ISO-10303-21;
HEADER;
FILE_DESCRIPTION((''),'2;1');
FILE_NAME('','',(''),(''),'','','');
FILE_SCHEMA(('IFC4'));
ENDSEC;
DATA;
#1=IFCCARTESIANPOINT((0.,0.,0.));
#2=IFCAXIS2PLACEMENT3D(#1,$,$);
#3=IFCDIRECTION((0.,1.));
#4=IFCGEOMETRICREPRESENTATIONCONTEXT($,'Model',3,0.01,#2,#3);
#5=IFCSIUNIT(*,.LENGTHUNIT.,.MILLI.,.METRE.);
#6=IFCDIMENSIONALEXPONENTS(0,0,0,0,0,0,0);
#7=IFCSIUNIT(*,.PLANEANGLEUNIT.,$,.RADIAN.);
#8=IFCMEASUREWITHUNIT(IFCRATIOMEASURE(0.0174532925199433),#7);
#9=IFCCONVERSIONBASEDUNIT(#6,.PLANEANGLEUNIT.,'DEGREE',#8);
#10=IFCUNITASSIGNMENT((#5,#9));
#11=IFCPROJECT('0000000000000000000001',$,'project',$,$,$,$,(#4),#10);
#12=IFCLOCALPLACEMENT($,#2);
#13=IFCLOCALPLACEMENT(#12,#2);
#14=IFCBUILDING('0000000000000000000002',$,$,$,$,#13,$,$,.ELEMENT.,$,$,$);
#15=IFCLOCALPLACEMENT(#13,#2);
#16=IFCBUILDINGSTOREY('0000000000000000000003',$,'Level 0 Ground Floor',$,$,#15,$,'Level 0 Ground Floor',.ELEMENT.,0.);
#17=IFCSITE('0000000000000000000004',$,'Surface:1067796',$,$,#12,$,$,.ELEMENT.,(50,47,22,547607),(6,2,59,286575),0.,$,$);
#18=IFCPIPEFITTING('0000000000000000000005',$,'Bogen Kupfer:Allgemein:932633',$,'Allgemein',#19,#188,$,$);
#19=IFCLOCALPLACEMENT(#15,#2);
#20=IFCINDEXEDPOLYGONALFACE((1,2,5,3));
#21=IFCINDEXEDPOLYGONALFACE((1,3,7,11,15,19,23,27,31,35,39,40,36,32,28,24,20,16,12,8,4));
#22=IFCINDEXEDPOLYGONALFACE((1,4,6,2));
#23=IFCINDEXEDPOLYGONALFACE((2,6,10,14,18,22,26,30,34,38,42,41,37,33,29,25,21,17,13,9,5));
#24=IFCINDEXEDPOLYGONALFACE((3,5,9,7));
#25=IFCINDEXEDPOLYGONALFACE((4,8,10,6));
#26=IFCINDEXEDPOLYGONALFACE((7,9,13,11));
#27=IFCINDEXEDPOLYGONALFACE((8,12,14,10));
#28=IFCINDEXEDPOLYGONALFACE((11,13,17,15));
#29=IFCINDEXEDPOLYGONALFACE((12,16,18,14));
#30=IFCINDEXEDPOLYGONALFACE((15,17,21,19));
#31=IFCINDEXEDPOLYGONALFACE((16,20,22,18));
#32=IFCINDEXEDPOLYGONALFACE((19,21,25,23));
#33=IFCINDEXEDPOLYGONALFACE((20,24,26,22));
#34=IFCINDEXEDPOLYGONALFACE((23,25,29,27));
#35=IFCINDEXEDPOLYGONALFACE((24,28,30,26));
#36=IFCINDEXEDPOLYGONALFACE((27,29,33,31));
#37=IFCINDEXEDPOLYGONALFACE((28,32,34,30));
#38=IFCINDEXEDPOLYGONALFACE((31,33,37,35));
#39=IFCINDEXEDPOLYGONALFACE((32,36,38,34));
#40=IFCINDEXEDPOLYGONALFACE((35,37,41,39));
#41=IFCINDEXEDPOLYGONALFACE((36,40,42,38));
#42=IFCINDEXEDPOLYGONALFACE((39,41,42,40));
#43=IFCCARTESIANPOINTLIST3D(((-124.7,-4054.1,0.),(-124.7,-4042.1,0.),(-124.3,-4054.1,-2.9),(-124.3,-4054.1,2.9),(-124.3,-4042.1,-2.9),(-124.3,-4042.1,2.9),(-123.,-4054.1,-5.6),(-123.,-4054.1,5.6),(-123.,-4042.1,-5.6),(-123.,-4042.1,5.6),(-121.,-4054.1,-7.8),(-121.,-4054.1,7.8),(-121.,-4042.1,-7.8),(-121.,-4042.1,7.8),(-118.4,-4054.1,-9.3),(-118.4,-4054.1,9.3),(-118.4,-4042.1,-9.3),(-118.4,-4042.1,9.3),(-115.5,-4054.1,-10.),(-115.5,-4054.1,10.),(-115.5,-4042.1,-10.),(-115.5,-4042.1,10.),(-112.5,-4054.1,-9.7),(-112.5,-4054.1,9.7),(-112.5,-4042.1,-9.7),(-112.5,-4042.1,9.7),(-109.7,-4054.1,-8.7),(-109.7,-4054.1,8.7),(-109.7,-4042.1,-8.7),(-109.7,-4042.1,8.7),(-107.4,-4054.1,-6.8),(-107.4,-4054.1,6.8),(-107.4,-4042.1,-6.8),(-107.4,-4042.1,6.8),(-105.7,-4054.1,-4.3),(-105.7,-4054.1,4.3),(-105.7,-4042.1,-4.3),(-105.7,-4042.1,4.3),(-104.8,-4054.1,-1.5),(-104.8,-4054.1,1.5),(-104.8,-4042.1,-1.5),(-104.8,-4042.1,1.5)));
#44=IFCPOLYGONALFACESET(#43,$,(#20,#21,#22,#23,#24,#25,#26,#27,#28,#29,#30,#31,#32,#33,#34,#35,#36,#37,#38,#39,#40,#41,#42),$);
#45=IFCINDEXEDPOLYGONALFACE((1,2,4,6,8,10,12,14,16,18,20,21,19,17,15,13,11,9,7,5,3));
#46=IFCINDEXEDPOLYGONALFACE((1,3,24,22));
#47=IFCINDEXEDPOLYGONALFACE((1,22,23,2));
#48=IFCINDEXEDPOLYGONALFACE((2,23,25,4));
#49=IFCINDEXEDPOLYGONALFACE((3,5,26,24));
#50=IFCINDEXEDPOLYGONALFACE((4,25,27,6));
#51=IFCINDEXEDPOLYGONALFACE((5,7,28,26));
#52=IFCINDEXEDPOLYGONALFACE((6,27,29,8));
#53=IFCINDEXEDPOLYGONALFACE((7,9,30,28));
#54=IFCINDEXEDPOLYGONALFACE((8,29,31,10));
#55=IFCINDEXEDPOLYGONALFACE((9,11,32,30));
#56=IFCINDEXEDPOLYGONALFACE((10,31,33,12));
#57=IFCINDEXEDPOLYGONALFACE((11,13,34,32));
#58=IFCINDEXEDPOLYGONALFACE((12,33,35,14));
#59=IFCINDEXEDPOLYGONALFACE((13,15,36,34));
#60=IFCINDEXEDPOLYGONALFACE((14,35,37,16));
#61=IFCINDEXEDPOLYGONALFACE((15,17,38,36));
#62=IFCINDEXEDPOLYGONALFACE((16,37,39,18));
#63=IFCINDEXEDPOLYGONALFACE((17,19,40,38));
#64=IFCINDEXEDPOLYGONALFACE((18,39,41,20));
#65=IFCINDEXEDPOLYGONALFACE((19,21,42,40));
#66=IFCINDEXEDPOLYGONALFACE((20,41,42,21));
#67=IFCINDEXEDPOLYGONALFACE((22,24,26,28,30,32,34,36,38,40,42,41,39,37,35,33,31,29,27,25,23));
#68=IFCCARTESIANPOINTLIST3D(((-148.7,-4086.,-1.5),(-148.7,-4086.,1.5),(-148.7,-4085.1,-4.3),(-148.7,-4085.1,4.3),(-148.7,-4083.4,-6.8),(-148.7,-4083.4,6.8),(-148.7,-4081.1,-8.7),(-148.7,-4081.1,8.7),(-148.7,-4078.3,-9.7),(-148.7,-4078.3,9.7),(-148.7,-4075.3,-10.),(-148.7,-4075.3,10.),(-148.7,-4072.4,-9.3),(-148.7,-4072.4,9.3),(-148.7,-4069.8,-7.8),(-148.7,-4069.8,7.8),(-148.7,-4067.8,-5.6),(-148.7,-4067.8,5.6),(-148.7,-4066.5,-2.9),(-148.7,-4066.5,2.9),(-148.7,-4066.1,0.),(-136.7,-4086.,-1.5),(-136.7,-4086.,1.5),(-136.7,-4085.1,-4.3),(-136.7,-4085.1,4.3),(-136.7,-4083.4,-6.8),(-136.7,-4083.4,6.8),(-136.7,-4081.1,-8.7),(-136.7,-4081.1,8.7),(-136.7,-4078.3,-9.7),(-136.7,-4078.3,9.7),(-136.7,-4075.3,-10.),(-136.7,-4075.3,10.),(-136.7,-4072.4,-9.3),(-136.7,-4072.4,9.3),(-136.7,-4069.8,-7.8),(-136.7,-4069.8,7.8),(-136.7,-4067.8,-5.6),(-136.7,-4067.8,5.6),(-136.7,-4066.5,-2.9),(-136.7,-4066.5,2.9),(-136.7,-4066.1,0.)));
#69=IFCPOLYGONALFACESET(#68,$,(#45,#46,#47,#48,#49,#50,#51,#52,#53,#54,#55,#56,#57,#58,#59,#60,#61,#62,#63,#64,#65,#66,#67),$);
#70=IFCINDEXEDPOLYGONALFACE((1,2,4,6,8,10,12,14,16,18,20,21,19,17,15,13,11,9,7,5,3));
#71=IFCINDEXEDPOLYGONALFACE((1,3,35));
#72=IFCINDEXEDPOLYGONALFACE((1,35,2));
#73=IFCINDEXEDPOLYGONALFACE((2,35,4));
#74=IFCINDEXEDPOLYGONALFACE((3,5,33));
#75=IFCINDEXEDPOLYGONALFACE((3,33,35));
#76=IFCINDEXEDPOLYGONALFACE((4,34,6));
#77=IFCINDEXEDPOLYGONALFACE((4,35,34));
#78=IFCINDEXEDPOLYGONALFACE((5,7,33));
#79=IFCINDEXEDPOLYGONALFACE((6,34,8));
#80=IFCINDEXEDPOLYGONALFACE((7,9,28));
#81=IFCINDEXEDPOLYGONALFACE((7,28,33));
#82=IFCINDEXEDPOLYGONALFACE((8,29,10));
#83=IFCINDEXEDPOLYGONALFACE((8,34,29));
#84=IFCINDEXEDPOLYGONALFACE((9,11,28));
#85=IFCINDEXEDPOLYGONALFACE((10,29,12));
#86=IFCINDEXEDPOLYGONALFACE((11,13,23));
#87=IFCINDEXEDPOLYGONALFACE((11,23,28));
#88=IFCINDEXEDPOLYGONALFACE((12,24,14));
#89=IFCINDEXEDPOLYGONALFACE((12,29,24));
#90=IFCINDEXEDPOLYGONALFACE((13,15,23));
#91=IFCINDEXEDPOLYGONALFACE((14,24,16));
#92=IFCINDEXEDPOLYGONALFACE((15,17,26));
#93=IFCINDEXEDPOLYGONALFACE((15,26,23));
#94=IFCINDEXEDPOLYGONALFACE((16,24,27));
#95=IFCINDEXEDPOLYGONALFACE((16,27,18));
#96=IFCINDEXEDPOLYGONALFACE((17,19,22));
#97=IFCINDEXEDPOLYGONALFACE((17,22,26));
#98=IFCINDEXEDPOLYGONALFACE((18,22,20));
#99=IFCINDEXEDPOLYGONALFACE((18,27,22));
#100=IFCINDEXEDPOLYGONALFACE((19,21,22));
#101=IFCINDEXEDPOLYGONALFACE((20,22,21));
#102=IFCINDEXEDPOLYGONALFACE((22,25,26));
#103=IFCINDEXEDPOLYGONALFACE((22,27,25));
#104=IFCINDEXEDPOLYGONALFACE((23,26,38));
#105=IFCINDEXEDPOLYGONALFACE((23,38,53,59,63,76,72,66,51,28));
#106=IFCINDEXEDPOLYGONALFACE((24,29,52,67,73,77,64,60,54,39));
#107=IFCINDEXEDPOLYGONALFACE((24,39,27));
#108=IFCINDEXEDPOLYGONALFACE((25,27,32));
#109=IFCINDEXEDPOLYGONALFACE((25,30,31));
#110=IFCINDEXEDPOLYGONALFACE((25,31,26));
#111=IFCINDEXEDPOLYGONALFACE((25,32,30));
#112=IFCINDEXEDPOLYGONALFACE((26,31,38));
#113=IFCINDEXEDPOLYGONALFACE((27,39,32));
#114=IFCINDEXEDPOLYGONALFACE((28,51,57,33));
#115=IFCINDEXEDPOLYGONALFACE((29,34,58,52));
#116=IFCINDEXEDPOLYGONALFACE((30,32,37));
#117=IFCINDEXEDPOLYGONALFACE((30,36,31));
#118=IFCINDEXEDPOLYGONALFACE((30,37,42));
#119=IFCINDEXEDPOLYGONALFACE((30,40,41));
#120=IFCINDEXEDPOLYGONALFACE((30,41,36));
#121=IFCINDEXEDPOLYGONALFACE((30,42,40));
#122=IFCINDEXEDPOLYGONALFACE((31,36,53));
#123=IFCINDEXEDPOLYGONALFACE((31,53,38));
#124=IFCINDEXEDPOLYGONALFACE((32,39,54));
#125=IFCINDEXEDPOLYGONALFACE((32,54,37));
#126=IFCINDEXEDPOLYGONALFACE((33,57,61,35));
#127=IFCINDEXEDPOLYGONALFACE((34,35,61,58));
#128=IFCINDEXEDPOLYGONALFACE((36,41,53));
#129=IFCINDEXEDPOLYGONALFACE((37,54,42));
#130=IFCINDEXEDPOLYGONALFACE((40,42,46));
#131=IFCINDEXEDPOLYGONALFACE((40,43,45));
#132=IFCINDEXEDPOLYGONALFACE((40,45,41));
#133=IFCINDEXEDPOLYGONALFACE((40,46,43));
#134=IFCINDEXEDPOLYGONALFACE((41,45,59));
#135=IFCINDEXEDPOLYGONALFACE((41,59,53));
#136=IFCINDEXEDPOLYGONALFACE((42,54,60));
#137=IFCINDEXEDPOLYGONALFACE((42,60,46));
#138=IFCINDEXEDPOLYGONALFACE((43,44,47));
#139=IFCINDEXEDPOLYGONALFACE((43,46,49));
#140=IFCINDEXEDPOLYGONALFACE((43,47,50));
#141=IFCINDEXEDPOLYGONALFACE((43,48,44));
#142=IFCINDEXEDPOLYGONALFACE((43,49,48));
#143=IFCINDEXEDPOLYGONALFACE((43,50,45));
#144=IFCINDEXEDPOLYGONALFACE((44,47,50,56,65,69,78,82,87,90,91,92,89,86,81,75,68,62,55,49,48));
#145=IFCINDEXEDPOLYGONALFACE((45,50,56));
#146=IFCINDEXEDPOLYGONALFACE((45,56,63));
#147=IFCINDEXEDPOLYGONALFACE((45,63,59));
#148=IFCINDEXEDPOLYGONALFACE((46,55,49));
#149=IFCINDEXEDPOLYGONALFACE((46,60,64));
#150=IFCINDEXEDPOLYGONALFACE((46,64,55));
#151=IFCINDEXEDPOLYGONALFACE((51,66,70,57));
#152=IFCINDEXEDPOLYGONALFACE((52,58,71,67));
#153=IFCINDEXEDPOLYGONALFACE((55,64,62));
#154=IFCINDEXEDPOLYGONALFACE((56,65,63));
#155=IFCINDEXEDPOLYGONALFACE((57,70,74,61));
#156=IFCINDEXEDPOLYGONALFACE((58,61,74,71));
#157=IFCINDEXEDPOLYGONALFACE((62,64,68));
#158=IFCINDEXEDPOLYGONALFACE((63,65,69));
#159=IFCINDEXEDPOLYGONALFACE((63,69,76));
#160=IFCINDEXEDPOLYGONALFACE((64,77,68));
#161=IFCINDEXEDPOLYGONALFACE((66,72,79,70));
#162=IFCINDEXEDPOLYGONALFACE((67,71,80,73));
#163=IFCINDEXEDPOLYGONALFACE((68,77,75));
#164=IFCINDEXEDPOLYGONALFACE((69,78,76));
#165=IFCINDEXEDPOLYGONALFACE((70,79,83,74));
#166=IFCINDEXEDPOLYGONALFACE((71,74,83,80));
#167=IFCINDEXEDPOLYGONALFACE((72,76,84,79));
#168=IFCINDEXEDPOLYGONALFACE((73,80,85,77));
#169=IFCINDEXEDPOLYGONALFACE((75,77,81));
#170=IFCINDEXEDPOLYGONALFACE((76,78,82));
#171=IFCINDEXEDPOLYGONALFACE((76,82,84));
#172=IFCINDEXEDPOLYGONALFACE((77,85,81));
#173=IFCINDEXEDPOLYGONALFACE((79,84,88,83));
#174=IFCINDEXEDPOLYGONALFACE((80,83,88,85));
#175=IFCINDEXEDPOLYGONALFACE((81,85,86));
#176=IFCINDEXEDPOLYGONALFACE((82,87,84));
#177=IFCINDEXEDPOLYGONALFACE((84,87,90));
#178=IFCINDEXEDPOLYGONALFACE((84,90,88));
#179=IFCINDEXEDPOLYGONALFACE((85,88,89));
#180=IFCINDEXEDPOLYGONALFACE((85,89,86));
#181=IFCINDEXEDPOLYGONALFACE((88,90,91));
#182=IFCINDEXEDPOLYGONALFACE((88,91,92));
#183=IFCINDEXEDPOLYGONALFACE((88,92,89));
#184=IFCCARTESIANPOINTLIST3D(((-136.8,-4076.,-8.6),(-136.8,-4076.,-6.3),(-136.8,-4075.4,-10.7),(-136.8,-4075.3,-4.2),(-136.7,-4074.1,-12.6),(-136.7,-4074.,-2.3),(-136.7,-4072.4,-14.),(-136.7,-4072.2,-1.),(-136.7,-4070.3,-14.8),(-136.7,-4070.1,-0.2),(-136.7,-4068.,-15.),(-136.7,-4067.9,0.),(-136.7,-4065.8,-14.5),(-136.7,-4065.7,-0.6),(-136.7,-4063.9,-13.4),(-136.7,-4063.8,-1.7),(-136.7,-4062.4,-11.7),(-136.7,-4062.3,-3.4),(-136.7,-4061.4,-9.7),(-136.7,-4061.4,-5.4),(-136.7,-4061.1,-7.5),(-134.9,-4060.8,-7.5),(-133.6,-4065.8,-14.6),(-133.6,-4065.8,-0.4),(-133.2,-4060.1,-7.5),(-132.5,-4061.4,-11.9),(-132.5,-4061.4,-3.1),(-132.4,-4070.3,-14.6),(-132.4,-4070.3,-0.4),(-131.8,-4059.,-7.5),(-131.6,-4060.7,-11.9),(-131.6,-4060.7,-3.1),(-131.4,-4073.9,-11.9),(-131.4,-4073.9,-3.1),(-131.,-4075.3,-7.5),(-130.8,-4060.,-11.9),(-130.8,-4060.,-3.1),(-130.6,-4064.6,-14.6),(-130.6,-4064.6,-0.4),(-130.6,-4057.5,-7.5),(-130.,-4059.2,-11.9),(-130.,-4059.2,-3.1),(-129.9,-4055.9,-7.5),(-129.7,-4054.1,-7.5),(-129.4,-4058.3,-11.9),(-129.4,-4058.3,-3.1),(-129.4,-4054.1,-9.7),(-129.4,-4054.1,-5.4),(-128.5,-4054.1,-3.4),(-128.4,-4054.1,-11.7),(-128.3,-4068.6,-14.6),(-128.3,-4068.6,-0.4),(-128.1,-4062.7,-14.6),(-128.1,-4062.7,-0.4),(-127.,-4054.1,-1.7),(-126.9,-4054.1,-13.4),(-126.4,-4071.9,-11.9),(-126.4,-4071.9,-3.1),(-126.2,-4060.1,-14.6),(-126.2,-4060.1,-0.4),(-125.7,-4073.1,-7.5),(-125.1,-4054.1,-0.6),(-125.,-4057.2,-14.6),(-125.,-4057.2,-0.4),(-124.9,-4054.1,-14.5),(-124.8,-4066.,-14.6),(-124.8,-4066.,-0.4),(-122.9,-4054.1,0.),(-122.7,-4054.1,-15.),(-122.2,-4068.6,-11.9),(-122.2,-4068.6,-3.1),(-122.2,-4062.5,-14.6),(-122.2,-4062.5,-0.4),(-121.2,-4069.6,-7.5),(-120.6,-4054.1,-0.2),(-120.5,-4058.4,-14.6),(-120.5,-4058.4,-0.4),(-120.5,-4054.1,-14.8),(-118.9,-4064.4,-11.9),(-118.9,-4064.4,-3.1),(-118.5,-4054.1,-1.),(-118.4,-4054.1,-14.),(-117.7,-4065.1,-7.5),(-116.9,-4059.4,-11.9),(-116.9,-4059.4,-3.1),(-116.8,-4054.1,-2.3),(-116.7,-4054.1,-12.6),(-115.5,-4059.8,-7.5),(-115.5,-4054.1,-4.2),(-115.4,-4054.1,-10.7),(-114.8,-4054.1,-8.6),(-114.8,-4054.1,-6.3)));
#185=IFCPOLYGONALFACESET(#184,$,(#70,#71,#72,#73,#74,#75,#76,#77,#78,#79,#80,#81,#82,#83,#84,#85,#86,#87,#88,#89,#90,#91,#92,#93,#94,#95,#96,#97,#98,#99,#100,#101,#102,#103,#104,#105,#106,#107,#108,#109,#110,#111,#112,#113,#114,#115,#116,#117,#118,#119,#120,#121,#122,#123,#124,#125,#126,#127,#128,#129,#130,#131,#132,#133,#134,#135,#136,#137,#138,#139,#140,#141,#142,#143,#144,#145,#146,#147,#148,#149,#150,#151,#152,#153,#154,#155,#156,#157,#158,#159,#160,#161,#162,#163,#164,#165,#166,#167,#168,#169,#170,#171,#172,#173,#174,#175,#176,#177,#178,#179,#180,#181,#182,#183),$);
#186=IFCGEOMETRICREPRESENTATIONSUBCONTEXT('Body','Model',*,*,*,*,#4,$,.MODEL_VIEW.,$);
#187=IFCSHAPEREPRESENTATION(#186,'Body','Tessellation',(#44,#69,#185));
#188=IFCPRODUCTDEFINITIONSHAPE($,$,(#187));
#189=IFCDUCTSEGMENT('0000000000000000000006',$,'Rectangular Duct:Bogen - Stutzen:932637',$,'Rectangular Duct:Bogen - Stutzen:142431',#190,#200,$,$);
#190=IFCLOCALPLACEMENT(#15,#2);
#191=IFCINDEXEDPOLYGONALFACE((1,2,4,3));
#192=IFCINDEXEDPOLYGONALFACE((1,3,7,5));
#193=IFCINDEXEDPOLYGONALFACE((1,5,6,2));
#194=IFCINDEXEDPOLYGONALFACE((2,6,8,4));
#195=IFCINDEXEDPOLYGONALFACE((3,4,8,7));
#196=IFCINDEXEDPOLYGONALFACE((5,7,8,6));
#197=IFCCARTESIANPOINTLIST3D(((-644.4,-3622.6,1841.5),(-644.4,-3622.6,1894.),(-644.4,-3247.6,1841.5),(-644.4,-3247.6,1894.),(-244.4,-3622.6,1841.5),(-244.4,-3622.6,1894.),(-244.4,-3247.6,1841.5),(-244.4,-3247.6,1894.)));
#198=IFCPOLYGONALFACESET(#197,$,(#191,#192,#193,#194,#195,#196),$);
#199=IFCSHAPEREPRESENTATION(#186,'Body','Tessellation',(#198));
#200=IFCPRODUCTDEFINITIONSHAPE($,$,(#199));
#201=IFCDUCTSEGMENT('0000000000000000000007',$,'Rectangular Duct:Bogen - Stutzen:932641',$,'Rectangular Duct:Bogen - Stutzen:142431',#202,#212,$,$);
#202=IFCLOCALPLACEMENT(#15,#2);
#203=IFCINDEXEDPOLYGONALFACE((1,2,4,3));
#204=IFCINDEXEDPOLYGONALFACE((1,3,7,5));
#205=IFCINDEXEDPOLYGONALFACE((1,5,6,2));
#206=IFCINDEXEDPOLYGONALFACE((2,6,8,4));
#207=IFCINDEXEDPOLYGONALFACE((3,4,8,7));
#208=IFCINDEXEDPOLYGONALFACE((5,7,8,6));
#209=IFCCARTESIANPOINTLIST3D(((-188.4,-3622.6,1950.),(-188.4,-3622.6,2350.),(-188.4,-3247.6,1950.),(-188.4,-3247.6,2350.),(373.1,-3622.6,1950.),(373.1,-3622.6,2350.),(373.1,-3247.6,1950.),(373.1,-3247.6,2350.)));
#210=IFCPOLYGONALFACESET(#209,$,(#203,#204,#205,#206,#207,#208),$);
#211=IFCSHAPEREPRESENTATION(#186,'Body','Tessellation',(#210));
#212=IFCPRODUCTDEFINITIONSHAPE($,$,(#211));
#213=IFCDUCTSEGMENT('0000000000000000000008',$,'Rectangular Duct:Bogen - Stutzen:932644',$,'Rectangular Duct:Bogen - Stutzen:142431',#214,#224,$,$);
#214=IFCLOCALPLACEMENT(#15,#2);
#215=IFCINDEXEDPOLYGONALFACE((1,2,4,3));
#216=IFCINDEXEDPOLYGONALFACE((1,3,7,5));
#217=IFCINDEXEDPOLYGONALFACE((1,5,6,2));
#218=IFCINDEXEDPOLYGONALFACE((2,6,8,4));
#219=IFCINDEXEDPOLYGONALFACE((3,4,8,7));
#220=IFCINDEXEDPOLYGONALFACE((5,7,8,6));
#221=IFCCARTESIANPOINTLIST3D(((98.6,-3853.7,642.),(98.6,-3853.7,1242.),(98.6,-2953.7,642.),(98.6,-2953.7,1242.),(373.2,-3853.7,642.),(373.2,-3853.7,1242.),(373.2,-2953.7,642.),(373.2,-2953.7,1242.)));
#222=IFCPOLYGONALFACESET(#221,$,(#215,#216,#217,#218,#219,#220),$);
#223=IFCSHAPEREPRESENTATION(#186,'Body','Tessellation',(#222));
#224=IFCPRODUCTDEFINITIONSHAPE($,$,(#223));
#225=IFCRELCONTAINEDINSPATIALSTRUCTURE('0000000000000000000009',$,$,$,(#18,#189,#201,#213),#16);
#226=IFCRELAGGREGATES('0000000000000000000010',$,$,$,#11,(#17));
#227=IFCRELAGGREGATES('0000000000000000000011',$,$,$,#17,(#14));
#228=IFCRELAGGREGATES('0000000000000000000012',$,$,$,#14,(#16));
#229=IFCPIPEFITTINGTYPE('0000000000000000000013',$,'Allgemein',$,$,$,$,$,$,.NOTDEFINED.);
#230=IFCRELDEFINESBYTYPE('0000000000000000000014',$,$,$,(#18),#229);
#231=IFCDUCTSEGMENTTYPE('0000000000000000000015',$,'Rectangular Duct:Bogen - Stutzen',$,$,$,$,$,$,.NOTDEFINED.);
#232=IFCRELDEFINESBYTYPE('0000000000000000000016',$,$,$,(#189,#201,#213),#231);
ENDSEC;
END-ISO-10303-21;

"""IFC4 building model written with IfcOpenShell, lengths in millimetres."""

from ifc_helpers import new_model, entity, si_unit, converted_unit, direction, frame, frame_2d, origin, origin_2d_with_axis, place, context, subcontext, project, spatial, rectangle, circle, extrude, source, transform, mapped, type_object, type_shapes, element, save


model = new_model("IFC4")

# Units and contexts
model_context = context("Model", 3, precision=0.01, world=origin(), true_north=direction((0.0, 1.0)))
body_context = subcontext(model_context, "Body", "Model", "MODEL_VIEW")
ifc_project = project(units=[si_unit("LENGTHUNIT", "METRE", prefix="MILLI"), converted_unit("PLANEANGLEUNIT", "DEGREE", entity("IfcRatioMeasure", 0.0174532925199433), si_unit("PLANEANGLEUNIT", "RADIAN"), dimensions=[0, 0, 0, 0, 0, 0, 0])], contexts=[model_context])

# Site, building, storey
site_placement = place(None, origin())
site = spatial("IfcSite", under=ifc_project, at=site_placement, Name="Surface:1067796", CompositionType="ELEMENT", RefLatitude=(50, 47, 22, 547607), RefLongitude=(6, 2, 59, 286575), RefElevation=0.0)
building_placement = place(site_placement, origin())
building = spatial("IfcBuilding", under=site, at=building_placement, CompositionType="ELEMENT")
storey_placement = place(building_placement, origin())
storey = spatial("IfcBuildingStorey", under=building, at=storey_placement, Name="Level 0 Ground Floor", LongName="Level 0 Ground Floor", CompositionType="ELEMENT", Elevation=0.0)

# Pipe fitting
pipe_fitting_type_1 = type_object("IfcPipeFittingType", Name="Allgemein", PredefinedType="NOTDEFINED")
ifc_direction = entity("IfcDirection", [0.0, 0.0, -1.0])
trimmed_curve = entity("IfcTrimmedCurve", entity("IfcCircle", entity("IfcAxis2Placement2D", entity("IfcCartesianPoint", [-14.5, 0.0]), entity("IfcDirection", [0.0, 1.0])), 14.5), [entity("IfcParameterValue", 270.0)], [entity("IfcParameterValue", 0.0)], True, "PARAMETER")
shared_shape_1 = source(origin(), body_context, "Body", "SolidModel", [
    extrude(circle(Radius=10.0, at=frame_2d((0.0, 0.0), x_axis=(1.0, 0.0))), frame((0.0, 22.0, 0.0), z_axis=(0.0, 1.0, 0.0), x_axis=(-1.0, 0.0, 0.0)), (0.0, 0.0, 1.0), 12.0),
    extrude(circle(Radius=10.0, at=frame_2d((0.0, 0.0), x_axis=(1.0, 0.0))), frame((-34.0, 0.0, 0.0), z_axis=(1.0, 0.0, 0.0), x_axis=(0.0, 1.0, 0.0)), (0.0, 0.0, 1.0), 12.0),
    entity("IfcSurfaceCurveSweptAreaSolid", entity("IfcCircleProfileDef", "AREA", None, entity("IfcAxis2Placement2D", entity("IfcCartesianPoint", [0.0, 7.5]), entity("IfcDirection", [1.0, 0.0])), 7.5), entity("IfcAxis2Placement3D", entity("IfcCartesianPoint", [-7.5, 22.0, 0.0]), ifc_direction, entity("IfcDirection", [1.0, 0.0, 0.0])), trimmed_curve, 0.0, 90.0, entity("IfcSurfaceOfLinearExtrusion", entity("IfcArbitraryOpenProfileDef", "CURVE", None, trimmed_curve), entity("IfcAxis2Placement3D", entity("IfcCartesianPoint", [0.0, 0.0, -304.8])), ifc_direction, 1.0)),
])
type_shapes(pipe_fitting_type_1, [shared_shape_1])
pipe_fitting_1_placement = place(storey_placement, frame((-114.7, -4076.1, 0.0)))
element("IfcPipeFitting", 1, at=pipe_fitting_1_placement, inside=storey, type_object=pipe_fitting_type_1, Name="Bogen Kupfer:Allgemein:932633", ObjectType="Allgemein", context=body_context, shape_type="MappedRepresentation", body=[
    mapped(shared_shape_1, transform((0.0, 0.0, 0.0), scale=1.0)),
])

# Duct segments
duct_segment_type = type_object("IfcDuctSegmentType", Name="Rectangular Duct:Bogen - Stutzen", PredefinedType="NOTDEFINED")
duct_segment_1_placement = place(storey_placement, frame((-644.4, -3622.6, 1841.5)))
element("IfcDuctSegment", 2, at=duct_segment_1_placement, inside=storey, type_object=duct_segment_type, Name="Rectangular Duct:Bogen - Stutzen:932637", ObjectType="Rectangular Duct:Bogen - Stutzen:142431", context=body_context, shape_type="SweptSolid", body=[
    extrude(rectangle(XDim=375.0, YDim=400.0, at=origin_2d_with_axis()), frame((200.0, 187.5, 0.0), z_axis=(0.0, 0.0, 1.0), x_axis=(0.0, 1.0, 0.0)), (0.0, 0.0, 1.0), 52.5),
])
duct_segment_2_placement = place(storey_placement, frame((-188.4, -3622.6, 1950.0)))
element("IfcDuctSegment", 3, at=duct_segment_2_placement, inside=storey, type_object=duct_segment_type, Name="Rectangular Duct:Bogen - Stutzen:932641", ObjectType="Rectangular Duct:Bogen - Stutzen:142431", context=body_context, shape_type="SweptSolid", body=[
    extrude(rectangle(XDim=561.5, YDim=375.0, at=origin_2d_with_axis()), frame((280.8, 187.5, 0.0)), (0.0, 0.0, 1.0), 400.0),
])
duct_segment_3_placement = place(storey_placement, frame((98.6, -3853.7, 642.0)))
element("IfcDuctSegment", 4, at=duct_segment_3_placement, inside=storey, type_object=duct_segment_type, Name="Rectangular Duct:Bogen - Stutzen:932644", ObjectType="Rectangular Duct:Bogen - Stutzen:142431", context=body_context, shape_type="SweptSolid", body=[
    extrude(rectangle(XDim=274.6, YDim=900.0, at=frame_2d((0.0, 0.0), x_axis=(1.0, 0.0))), frame((137.3, 450.0, 0.0)), (0.0, 0.0, 1.0), 600.0),
])

save(model, "model.ifc")
